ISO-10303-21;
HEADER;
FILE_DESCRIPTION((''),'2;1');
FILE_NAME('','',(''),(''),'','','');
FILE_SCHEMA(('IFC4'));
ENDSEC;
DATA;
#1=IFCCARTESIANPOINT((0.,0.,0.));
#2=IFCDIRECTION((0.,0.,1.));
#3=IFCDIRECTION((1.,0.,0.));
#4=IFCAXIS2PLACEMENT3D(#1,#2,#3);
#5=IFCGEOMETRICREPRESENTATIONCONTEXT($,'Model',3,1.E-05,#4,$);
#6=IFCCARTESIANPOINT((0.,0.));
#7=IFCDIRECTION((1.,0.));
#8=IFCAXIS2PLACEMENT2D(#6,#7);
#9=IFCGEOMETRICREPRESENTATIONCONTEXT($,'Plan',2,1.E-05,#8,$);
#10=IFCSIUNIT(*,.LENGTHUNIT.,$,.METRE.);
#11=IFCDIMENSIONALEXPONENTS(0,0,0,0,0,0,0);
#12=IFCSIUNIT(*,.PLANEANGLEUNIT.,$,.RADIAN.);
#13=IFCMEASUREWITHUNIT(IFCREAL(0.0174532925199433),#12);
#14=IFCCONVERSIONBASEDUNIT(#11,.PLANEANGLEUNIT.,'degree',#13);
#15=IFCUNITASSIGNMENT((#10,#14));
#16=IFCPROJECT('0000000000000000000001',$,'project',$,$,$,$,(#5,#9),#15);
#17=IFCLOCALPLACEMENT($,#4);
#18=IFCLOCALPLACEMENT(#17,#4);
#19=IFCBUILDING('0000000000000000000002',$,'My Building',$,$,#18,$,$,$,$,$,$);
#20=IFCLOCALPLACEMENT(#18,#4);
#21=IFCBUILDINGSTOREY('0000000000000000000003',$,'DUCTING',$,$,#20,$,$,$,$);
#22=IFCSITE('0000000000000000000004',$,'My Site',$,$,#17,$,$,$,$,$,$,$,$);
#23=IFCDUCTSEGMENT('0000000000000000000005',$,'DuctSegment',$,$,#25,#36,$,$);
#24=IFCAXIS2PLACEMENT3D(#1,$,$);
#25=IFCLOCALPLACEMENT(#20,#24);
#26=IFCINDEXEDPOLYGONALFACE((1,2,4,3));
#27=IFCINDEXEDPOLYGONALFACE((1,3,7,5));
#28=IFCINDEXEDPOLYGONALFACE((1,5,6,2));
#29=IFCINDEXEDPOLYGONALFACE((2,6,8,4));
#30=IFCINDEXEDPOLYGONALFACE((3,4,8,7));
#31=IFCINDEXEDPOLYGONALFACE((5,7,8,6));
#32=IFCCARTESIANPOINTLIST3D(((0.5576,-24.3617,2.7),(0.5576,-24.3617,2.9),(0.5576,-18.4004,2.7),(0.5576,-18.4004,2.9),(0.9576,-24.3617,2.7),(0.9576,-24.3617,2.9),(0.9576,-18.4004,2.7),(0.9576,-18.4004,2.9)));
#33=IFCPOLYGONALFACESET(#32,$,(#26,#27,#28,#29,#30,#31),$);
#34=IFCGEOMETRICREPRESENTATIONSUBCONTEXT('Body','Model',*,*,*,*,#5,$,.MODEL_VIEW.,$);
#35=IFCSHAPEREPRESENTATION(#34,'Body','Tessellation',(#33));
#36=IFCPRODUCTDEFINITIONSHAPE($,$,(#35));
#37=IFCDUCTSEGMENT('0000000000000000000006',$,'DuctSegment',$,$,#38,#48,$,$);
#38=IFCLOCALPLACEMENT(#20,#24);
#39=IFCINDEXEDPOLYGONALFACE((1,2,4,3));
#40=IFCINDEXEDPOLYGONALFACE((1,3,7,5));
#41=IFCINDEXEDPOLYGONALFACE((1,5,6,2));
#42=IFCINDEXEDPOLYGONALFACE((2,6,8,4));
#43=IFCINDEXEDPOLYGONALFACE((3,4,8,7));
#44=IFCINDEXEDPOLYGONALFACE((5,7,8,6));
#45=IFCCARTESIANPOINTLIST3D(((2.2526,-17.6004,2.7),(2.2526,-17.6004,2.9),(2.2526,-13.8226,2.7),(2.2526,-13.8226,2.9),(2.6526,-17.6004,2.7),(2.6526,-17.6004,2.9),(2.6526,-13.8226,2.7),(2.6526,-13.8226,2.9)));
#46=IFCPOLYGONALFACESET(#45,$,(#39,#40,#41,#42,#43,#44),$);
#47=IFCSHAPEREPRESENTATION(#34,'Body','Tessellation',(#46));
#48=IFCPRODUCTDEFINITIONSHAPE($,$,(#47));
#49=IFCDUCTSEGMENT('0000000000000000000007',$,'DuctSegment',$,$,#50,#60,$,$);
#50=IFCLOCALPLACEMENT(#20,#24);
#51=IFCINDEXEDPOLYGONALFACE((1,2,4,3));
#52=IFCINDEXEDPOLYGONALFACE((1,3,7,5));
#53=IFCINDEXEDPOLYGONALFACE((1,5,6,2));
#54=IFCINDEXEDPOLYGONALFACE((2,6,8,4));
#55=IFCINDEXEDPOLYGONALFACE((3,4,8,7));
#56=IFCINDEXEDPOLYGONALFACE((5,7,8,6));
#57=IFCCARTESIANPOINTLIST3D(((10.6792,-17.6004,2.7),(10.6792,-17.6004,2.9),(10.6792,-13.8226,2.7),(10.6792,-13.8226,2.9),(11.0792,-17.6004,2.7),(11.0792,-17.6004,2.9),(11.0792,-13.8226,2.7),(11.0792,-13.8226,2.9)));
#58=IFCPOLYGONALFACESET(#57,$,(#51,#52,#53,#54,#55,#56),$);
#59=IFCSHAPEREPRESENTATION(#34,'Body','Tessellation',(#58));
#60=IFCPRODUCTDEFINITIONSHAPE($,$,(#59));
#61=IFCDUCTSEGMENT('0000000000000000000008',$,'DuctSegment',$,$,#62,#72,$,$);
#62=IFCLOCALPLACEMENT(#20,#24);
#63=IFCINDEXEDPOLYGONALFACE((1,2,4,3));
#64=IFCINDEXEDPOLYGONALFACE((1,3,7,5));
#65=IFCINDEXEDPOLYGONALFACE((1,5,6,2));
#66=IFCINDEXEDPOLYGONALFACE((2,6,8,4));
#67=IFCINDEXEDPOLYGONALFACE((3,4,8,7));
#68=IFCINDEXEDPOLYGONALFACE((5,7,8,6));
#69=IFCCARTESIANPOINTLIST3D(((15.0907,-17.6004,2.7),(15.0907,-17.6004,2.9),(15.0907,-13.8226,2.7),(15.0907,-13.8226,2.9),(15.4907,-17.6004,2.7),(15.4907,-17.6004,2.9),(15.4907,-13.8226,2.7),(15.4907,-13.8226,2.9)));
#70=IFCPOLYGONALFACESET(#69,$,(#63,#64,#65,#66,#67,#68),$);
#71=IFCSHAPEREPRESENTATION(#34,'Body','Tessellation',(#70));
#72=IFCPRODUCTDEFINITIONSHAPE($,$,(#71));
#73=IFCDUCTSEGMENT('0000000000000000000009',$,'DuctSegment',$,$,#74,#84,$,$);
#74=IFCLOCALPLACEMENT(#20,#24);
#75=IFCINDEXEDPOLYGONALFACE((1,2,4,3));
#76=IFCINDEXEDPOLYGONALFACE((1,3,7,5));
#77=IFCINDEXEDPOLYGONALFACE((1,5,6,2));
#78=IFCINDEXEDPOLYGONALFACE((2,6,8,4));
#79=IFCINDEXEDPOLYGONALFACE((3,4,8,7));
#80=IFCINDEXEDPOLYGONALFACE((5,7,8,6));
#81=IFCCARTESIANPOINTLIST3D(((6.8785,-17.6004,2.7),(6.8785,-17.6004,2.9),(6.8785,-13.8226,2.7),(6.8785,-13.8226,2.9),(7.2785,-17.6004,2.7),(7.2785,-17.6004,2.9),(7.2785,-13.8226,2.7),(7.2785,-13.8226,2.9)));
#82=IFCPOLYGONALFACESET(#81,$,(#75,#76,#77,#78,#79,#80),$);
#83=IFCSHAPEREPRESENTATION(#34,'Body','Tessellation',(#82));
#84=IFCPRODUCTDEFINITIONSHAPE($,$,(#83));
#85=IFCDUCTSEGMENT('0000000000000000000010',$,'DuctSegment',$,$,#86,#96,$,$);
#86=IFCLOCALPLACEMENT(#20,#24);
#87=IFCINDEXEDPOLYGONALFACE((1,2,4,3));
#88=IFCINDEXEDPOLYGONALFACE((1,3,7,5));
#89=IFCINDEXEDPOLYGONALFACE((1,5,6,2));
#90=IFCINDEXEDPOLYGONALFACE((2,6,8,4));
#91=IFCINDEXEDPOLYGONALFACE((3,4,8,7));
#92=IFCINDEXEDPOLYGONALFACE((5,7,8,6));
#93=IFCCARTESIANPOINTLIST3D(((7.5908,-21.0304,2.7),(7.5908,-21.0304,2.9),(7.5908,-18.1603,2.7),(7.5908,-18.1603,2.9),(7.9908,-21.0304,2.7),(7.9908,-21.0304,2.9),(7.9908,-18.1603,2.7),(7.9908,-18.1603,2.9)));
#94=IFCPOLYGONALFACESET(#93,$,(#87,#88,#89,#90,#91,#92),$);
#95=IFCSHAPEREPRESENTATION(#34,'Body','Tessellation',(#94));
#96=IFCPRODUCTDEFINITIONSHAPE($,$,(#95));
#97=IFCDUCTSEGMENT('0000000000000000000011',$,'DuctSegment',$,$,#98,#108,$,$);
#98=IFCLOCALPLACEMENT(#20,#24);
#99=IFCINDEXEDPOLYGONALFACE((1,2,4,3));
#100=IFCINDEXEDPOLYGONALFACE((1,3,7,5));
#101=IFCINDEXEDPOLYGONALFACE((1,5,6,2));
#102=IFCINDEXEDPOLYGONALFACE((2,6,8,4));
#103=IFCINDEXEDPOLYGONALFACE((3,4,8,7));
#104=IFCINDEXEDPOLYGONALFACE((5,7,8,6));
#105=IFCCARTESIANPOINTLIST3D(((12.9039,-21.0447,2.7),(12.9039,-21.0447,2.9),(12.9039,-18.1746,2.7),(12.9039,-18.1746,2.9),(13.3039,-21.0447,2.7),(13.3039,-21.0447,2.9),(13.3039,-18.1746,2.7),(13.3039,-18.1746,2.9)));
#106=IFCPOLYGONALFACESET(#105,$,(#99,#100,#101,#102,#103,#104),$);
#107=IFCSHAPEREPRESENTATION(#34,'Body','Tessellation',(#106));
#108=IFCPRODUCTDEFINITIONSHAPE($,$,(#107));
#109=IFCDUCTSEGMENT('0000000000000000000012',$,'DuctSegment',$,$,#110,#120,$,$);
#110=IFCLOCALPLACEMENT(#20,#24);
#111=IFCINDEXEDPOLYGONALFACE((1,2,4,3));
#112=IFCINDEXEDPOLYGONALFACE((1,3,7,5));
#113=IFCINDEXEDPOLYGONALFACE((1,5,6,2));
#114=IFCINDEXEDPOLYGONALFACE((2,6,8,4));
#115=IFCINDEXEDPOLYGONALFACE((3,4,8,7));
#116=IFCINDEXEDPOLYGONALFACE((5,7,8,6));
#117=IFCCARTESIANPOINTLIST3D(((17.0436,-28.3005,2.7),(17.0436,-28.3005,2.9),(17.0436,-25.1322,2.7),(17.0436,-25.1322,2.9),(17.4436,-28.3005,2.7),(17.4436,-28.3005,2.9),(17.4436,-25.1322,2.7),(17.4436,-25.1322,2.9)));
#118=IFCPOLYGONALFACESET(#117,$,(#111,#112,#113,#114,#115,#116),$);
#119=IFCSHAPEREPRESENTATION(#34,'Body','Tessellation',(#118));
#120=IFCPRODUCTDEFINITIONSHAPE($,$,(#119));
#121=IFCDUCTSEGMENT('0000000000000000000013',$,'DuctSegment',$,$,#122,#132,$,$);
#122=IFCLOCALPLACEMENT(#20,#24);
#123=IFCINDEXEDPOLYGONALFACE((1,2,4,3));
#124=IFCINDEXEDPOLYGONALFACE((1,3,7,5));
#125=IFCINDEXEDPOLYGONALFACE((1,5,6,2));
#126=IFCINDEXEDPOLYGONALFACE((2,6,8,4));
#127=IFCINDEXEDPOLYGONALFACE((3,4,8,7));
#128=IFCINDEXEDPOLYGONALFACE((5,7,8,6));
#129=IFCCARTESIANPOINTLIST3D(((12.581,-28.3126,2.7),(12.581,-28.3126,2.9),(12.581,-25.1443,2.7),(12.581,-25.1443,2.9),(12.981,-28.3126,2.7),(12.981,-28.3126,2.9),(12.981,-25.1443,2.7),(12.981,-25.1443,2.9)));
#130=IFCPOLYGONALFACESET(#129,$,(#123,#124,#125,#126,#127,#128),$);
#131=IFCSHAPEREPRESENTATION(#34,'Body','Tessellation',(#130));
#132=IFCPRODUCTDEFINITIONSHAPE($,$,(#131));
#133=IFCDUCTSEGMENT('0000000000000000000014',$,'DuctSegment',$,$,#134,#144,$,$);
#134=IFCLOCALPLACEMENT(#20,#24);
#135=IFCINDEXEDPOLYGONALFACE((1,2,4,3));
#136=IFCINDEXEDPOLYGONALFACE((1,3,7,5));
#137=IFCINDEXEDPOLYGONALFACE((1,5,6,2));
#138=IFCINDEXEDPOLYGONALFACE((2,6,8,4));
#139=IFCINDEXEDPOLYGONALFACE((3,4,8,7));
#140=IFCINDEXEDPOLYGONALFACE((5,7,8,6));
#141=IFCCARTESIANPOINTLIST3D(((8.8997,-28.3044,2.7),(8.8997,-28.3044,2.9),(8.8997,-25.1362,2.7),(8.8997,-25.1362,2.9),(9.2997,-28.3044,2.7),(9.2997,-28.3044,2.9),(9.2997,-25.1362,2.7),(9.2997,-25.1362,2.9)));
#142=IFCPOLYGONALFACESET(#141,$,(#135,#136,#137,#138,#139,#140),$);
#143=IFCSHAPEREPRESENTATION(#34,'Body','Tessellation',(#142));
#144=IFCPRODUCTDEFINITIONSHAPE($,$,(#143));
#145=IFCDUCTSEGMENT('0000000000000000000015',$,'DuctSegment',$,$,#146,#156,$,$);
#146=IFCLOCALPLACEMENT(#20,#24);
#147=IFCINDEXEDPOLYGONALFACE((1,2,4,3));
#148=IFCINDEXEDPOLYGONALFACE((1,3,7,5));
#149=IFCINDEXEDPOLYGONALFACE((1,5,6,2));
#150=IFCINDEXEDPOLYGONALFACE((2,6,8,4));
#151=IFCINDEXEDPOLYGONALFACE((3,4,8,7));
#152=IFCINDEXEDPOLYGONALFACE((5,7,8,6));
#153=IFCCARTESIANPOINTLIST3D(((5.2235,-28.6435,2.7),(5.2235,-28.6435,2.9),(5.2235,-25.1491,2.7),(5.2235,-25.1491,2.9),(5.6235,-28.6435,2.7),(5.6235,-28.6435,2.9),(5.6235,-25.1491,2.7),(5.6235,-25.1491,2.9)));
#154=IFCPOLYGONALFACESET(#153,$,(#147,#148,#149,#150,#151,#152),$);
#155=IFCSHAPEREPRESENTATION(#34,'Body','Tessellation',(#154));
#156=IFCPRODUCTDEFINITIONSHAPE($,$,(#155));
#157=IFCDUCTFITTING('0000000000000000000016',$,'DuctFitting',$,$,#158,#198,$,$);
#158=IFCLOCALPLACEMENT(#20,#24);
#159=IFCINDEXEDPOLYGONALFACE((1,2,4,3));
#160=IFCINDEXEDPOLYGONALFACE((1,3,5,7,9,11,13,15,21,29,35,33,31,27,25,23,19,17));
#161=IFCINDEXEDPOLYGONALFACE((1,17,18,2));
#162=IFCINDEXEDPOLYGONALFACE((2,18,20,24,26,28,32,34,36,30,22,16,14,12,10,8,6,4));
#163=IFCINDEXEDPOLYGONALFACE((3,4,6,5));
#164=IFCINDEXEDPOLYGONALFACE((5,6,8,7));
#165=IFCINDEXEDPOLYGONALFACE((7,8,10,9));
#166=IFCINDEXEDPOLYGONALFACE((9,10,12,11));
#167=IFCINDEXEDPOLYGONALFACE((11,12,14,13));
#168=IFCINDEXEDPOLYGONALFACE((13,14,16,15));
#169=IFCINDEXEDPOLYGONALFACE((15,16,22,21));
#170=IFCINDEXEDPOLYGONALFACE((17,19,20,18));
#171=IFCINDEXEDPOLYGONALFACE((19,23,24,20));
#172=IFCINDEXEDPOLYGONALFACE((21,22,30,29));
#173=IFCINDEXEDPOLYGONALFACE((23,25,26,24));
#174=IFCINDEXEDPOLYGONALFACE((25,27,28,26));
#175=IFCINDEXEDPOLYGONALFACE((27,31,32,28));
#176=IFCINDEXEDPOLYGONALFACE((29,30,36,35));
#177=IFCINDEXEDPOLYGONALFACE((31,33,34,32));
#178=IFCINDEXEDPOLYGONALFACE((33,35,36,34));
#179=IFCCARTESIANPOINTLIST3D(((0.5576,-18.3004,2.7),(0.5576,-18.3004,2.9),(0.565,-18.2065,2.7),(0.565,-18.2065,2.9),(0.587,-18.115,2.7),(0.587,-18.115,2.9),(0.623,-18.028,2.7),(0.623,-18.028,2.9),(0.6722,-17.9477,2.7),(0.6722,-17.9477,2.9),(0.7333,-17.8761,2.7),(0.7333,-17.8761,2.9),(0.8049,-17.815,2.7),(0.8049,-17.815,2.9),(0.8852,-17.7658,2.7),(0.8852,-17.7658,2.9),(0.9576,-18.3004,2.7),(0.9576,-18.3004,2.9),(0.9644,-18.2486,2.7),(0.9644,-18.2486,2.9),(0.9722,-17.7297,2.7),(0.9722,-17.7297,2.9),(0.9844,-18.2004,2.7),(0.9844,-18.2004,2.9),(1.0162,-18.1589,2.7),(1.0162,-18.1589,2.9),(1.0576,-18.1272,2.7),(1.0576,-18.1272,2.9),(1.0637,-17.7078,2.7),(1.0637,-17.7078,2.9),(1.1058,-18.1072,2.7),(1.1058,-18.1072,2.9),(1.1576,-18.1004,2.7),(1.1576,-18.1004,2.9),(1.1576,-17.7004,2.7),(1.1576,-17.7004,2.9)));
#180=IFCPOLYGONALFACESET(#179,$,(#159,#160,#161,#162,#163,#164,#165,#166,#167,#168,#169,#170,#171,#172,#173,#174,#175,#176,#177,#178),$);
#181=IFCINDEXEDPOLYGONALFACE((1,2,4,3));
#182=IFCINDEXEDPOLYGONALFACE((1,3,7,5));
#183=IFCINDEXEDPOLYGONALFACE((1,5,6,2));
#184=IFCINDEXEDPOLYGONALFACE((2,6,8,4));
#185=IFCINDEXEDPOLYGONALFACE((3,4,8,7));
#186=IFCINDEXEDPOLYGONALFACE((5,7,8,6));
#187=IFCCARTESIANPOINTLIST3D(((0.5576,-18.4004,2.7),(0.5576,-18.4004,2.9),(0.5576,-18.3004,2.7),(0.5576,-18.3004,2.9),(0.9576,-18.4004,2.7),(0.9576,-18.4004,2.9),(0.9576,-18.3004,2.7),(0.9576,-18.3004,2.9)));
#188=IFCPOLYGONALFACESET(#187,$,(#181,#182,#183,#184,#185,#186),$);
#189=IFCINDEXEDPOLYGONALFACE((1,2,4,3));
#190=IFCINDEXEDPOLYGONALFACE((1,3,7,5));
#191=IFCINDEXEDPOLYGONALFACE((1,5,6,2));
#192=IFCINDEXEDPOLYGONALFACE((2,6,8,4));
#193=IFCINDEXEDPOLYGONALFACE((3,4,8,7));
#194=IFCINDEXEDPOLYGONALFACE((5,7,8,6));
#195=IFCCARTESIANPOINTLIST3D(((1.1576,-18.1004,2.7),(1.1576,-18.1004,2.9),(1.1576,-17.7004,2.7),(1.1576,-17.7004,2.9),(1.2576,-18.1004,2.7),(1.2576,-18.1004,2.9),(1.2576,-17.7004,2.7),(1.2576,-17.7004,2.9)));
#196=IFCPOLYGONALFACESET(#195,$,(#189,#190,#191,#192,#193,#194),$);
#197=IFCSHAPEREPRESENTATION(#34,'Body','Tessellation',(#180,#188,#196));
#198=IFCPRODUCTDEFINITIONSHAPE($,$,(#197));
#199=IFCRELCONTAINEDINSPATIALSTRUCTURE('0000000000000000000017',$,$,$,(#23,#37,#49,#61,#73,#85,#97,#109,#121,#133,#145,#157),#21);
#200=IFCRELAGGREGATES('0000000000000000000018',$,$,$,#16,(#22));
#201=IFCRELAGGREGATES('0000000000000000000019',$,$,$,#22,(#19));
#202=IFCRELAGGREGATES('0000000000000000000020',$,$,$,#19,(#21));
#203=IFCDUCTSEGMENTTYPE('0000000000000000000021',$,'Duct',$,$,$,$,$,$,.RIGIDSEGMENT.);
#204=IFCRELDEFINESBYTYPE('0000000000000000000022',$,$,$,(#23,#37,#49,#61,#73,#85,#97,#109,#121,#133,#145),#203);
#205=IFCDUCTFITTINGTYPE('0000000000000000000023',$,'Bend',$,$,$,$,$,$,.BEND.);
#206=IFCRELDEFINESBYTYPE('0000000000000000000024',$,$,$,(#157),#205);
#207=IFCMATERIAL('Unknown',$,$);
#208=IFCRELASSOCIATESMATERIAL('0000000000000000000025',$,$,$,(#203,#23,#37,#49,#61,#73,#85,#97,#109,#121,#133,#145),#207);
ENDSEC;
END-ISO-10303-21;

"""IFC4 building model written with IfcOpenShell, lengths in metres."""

from ifc_helpers import new_model, entity, si_unit, converted_unit, frame, origin_with_axes, origin_2d_with_axis, place, context, subcontext, project, spatial, line, arc, indexed_curve, rectangle, outline, extrude, source, transform, mapped, material, material_profile, profile_set, profile_usage, type_object, type_shapes, element, save


model = new_model("IFC4")

# Units and contexts
model_context = context("Model", 3, precision=1e-05, world=origin_with_axes())
plan_context = context("Plan", 2, precision=1e-05, world=origin_2d_with_axis())
body_context = subcontext(model_context, "Body", "Model", "MODEL_VIEW")
ifc_project = project(units=[si_unit("LENGTHUNIT", "METRE"), converted_unit("PLANEANGLEUNIT", "degree", entity("IfcReal", 0.0174532925199433), si_unit("PLANEANGLEUNIT", "RADIAN"), dimensions=[0, 0, 0, 0, 0, 0, 0])], contexts=[model_context, plan_context])

# Site, building, storey
site_placement = place(None, origin_with_axes())
site = spatial("IfcSite", under=ifc_project, at=site_placement, Name="My Site")
building_placement = place(site_placement, origin_with_axes())
building = spatial("IfcBuilding", under=site, at=building_placement, Name="My Building")
storey_placement = place(building_placement, origin_with_axes())
storey = spatial("IfcBuildingStorey", under=building, at=storey_placement, Name="DUCTING")

# Duct segments
ifc_material = material(Name="Unknown")
ifc_material_profile_1 = material_profile(ifc_material, rectangle(XDim=0.4, YDim=0.2))
ifc_profile_set_1 = profile_set([ifc_material_profile_1])
ifc_profile_usage_1 = profile_usage(ifc_profile_set_1, cardinal=5)
duct_segment_type = type_object("IfcDuctSegmentType", Name="Duct", PredefinedType="RIGIDSEGMENT", material=ifc_profile_set_1)
duct_segment_1_placement = place(storey_placement, frame((0.7576, -24.3617, 2.8), z_axis=(0.0, 1.0, 0.0), x_axis=(-1.0, 0.0, 0.0)))
element("IfcDuctSegment", 1, at=duct_segment_1_placement, inside=storey, type_object=duct_segment_type, material=ifc_profile_usage_1, Name="DuctSegment", context=body_context, shape_type="SweptSolid", body=[
    extrude(rectangle(XDim=0.4, YDim=0.2), origin_with_axes(), (0.0, 0.0, 1.0), 5.9613),
])
ifc_profile_usage_2 = profile_usage(ifc_profile_set_1, cardinal=5)
duct_segment_2_placement = place(storey_placement, frame((2.4526, -17.6004, 2.8), z_axis=(0.0, 1.0, 0.0), x_axis=(-1.0, 0.0, 0.0)))
element("IfcDuctSegment", 2, at=duct_segment_2_placement, inside=storey, type_object=duct_segment_type, material=ifc_profile_usage_2, Name="DuctSegment", context=body_context, shape_type="SweptSolid", body=[
    extrude(rectangle(XDim=0.4, YDim=0.2), origin_with_axes(), (0.0, 0.0, 1.0), 3.7777),
])
ifc_profile_usage_3 = profile_usage(ifc_profile_set_1, cardinal=5)
duct_segment_3_placement = place(storey_placement, frame((10.8792, -17.6004, 2.8), z_axis=(0.0, 1.0, 0.0), x_axis=(-1.0, 0.0, 0.0)))
element("IfcDuctSegment", 3, at=duct_segment_3_placement, inside=storey, type_object=duct_segment_type, material=ifc_profile_usage_3, Name="DuctSegment", context=body_context, shape_type="SweptSolid", body=[
    extrude(rectangle(XDim=0.4, YDim=0.2), origin_with_axes(), (0.0, 0.0, 1.0), 3.7777),
])
ifc_profile_usage_4 = profile_usage(ifc_profile_set_1, cardinal=5)
duct_segment_4_placement = place(storey_placement, frame((15.2907, -17.6004, 2.8), z_axis=(0.0, 1.0, 0.0), x_axis=(-1.0, 0.0, 0.0)))
element("IfcDuctSegment", 4, at=duct_segment_4_placement, inside=storey, type_object=duct_segment_type, material=ifc_profile_usage_4, Name="DuctSegment", context=body_context, shape_type="SweptSolid", body=[
    extrude(rectangle(XDim=0.4, YDim=0.2), origin_with_axes(), (0.0, 0.0, 1.0), 3.7777),
])
ifc_profile_usage_5 = profile_usage(ifc_profile_set_1, cardinal=5)
duct_segment_5_placement = place(storey_placement, frame((7.0785, -13.8226, 2.8), z_axis=(0.0, -1.0, 0.0), x_axis=(1.0, 0.0, 0.0)))
element("IfcDuctSegment", 5, at=duct_segment_5_placement, inside=storey, type_object=duct_segment_type, material=ifc_profile_usage_5, Name="DuctSegment", context=body_context, shape_type="SweptSolid", body=[
    extrude(rectangle(XDim=0.4, YDim=0.2), origin_with_axes(), (0.0, 0.0, 1.0), 3.7777),
])
ifc_profile_usage_6 = profile_usage(ifc_profile_set_1, cardinal=5)
duct_segment_6_placement = place(storey_placement, frame((7.7908, -21.0304, 2.8), z_axis=(-0.000001, 1.0, 0.0), x_axis=(-1.0, -0.000001, 0.0)))
element("IfcDuctSegment", 6, at=duct_segment_6_placement, inside=storey, type_object=duct_segment_type, material=ifc_profile_usage_6, Name="DuctSegment", context=body_context, shape_type="SweptSolid", body=[
    extrude(rectangle(XDim=0.4, YDim=0.2), origin_with_axes(), (0.0, 0.0, 1.0), 2.8701),
])
ifc_profile_usage_7 = profile_usage(ifc_profile_set_1, cardinal=5)
duct_segment_7_placement = place(storey_placement, frame((13.1039, -21.0447, 2.8), z_axis=(-0.000001, 1.0, 0.0), x_axis=(-1.0, -0.000001, 0.0)))
element("IfcDuctSegment", 7, at=duct_segment_7_placement, inside=storey, type_object=duct_segment_type, material=ifc_profile_usage_7, Name="DuctSegment", context=body_context, shape_type="SweptSolid", body=[
    extrude(rectangle(XDim=0.4, YDim=0.2), origin_with_axes(), (0.0, 0.0, 1.0), 2.8701),
])
ifc_profile_usage_8 = profile_usage(ifc_profile_set_1, cardinal=5)
duct_segment_8_placement = place(storey_placement, frame((17.2436, -28.3005, 2.8), z_axis=(0.0, 1.0, 0.0), x_axis=(-1.0, 0.0, 0.0)))
element("IfcDuctSegment", 8, at=duct_segment_8_placement, inside=storey, type_object=duct_segment_type, material=ifc_profile_usage_8, Name="DuctSegment", context=body_context, shape_type="SweptSolid", body=[
    extrude(rectangle(XDim=0.4, YDim=0.2), origin_with_axes(), (0.0, 0.0, 1.0), 3.1683),
])
ifc_profile_usage_9 = profile_usage(ifc_profile_set_1, cardinal=5)
duct_segment_9_placement = place(storey_placement, frame((12.781, -28.3126, 2.8), z_axis=(0.0, 1.0, 0.0), x_axis=(-1.0, 0.0, 0.0)))
element("IfcDuctSegment", 9, at=duct_segment_9_placement, inside=storey, type_object=duct_segment_type, material=ifc_profile_usage_9, Name="DuctSegment", context=body_context, shape_type="SweptSolid", body=[
    extrude(rectangle(XDim=0.4, YDim=0.2), origin_with_axes(), (0.0, 0.0, 1.0), 3.1683),
])
ifc_profile_usage_10 = profile_usage(ifc_profile_set_1, cardinal=5)
duct_segment_10_placement = place(storey_placement, frame((9.0997, -28.3044, 2.8), z_axis=(0.0, 1.0, 0.0), x_axis=(-1.0, 0.0, 0.0)))
element("IfcDuctSegment", 10, at=duct_segment_10_placement, inside=storey, type_object=duct_segment_type, material=ifc_profile_usage_10, Name="DuctSegment", context=body_context, shape_type="SweptSolid", body=[
    extrude(rectangle(XDim=0.4, YDim=0.2), origin_with_axes(), (0.0, 0.0, 1.0), 3.1683),
])
ifc_profile_usage_11 = profile_usage(ifc_profile_set_1, cardinal=5)
duct_segment_11_placement = place(storey_placement, frame((5.4235, -25.1491, 2.8), z_axis=(0.0, -1.0, 0.0), x_axis=(1.0, 0.0, 0.0)))
element("IfcDuctSegment", 11, at=duct_segment_11_placement, inside=storey, type_object=duct_segment_type, material=ifc_profile_usage_11, Name="DuctSegment", context=body_context, shape_type="SweptSolid", body=[
    extrude(rectangle(XDim=0.4, YDim=0.2), origin_with_axes(), (0.0, 0.0, 1.0), 3.4944),
])

# Duct fitting
duct_fitting_type_1 = type_object("IfcDuctFittingType", Name="Bend", PredefinedType="BEND")
shared_shape = source(origin_with_axes(), body_context, "Body", "SweptSolid", [
    extrude(outline(indexed_curve([(-0.2, 0.0), (-0.2586, 0.1414), (-0.4, 0.2), (-0.4, 0.6), (0.0243, 0.4243), (0.2, 0.0)], segments=[arc(1, 2, 3), line(3, 4), arc(4, 5, 6), line(6, 1)])), frame((0.0, -0.1, 0.1), z_axis=(0.0, -1.0, 0.0), x_axis=(1.0, 0.0, 0.0)), (0.0, 0.0, -1.0), 0.2),
    extrude(rectangle(XDim=0.4, YDim=0.2), origin_with_axes(), (0.0, 0.0, 1.0), 0.1),
    extrude(rectangle(XDim=0.4, YDim=0.2), frame((-0.4, 0.0, 0.5), z_axis=(-1.0, 0.0, 0.0), x_axis=(0.0, 0.0, -1.0)), (0.0, 0.0, 1.0), 0.1),
])
type_shapes(duct_fitting_type_1, [shared_shape])
for number, where, z_axis, x_axis, name in (
    (12, (0.7576, -18.4004, 2.8), (0.0, 1.0, 0.0), (-1.0, 0.0, 0.0), "DuctFitting"),
):
    element("IfcDuctFitting", number, at=place(storey_placement, frame(where, z_axis=z_axis, x_axis=x_axis)), inside=storey, type_object=duct_fitting_type_1, Name=name, context=body_context, shape_type="MappedRepresentation", body=[
        mapped(shared_shape, transform((0.0, 0.0, 0.0), x_axis=(1.0, 0.0, 0.0), y_axis=(0.0, 1.0, 0.0), z_axis=(0.0, 0.0, 1.0), scale=1.0)),
    ])

save(model, "model.ifc")
